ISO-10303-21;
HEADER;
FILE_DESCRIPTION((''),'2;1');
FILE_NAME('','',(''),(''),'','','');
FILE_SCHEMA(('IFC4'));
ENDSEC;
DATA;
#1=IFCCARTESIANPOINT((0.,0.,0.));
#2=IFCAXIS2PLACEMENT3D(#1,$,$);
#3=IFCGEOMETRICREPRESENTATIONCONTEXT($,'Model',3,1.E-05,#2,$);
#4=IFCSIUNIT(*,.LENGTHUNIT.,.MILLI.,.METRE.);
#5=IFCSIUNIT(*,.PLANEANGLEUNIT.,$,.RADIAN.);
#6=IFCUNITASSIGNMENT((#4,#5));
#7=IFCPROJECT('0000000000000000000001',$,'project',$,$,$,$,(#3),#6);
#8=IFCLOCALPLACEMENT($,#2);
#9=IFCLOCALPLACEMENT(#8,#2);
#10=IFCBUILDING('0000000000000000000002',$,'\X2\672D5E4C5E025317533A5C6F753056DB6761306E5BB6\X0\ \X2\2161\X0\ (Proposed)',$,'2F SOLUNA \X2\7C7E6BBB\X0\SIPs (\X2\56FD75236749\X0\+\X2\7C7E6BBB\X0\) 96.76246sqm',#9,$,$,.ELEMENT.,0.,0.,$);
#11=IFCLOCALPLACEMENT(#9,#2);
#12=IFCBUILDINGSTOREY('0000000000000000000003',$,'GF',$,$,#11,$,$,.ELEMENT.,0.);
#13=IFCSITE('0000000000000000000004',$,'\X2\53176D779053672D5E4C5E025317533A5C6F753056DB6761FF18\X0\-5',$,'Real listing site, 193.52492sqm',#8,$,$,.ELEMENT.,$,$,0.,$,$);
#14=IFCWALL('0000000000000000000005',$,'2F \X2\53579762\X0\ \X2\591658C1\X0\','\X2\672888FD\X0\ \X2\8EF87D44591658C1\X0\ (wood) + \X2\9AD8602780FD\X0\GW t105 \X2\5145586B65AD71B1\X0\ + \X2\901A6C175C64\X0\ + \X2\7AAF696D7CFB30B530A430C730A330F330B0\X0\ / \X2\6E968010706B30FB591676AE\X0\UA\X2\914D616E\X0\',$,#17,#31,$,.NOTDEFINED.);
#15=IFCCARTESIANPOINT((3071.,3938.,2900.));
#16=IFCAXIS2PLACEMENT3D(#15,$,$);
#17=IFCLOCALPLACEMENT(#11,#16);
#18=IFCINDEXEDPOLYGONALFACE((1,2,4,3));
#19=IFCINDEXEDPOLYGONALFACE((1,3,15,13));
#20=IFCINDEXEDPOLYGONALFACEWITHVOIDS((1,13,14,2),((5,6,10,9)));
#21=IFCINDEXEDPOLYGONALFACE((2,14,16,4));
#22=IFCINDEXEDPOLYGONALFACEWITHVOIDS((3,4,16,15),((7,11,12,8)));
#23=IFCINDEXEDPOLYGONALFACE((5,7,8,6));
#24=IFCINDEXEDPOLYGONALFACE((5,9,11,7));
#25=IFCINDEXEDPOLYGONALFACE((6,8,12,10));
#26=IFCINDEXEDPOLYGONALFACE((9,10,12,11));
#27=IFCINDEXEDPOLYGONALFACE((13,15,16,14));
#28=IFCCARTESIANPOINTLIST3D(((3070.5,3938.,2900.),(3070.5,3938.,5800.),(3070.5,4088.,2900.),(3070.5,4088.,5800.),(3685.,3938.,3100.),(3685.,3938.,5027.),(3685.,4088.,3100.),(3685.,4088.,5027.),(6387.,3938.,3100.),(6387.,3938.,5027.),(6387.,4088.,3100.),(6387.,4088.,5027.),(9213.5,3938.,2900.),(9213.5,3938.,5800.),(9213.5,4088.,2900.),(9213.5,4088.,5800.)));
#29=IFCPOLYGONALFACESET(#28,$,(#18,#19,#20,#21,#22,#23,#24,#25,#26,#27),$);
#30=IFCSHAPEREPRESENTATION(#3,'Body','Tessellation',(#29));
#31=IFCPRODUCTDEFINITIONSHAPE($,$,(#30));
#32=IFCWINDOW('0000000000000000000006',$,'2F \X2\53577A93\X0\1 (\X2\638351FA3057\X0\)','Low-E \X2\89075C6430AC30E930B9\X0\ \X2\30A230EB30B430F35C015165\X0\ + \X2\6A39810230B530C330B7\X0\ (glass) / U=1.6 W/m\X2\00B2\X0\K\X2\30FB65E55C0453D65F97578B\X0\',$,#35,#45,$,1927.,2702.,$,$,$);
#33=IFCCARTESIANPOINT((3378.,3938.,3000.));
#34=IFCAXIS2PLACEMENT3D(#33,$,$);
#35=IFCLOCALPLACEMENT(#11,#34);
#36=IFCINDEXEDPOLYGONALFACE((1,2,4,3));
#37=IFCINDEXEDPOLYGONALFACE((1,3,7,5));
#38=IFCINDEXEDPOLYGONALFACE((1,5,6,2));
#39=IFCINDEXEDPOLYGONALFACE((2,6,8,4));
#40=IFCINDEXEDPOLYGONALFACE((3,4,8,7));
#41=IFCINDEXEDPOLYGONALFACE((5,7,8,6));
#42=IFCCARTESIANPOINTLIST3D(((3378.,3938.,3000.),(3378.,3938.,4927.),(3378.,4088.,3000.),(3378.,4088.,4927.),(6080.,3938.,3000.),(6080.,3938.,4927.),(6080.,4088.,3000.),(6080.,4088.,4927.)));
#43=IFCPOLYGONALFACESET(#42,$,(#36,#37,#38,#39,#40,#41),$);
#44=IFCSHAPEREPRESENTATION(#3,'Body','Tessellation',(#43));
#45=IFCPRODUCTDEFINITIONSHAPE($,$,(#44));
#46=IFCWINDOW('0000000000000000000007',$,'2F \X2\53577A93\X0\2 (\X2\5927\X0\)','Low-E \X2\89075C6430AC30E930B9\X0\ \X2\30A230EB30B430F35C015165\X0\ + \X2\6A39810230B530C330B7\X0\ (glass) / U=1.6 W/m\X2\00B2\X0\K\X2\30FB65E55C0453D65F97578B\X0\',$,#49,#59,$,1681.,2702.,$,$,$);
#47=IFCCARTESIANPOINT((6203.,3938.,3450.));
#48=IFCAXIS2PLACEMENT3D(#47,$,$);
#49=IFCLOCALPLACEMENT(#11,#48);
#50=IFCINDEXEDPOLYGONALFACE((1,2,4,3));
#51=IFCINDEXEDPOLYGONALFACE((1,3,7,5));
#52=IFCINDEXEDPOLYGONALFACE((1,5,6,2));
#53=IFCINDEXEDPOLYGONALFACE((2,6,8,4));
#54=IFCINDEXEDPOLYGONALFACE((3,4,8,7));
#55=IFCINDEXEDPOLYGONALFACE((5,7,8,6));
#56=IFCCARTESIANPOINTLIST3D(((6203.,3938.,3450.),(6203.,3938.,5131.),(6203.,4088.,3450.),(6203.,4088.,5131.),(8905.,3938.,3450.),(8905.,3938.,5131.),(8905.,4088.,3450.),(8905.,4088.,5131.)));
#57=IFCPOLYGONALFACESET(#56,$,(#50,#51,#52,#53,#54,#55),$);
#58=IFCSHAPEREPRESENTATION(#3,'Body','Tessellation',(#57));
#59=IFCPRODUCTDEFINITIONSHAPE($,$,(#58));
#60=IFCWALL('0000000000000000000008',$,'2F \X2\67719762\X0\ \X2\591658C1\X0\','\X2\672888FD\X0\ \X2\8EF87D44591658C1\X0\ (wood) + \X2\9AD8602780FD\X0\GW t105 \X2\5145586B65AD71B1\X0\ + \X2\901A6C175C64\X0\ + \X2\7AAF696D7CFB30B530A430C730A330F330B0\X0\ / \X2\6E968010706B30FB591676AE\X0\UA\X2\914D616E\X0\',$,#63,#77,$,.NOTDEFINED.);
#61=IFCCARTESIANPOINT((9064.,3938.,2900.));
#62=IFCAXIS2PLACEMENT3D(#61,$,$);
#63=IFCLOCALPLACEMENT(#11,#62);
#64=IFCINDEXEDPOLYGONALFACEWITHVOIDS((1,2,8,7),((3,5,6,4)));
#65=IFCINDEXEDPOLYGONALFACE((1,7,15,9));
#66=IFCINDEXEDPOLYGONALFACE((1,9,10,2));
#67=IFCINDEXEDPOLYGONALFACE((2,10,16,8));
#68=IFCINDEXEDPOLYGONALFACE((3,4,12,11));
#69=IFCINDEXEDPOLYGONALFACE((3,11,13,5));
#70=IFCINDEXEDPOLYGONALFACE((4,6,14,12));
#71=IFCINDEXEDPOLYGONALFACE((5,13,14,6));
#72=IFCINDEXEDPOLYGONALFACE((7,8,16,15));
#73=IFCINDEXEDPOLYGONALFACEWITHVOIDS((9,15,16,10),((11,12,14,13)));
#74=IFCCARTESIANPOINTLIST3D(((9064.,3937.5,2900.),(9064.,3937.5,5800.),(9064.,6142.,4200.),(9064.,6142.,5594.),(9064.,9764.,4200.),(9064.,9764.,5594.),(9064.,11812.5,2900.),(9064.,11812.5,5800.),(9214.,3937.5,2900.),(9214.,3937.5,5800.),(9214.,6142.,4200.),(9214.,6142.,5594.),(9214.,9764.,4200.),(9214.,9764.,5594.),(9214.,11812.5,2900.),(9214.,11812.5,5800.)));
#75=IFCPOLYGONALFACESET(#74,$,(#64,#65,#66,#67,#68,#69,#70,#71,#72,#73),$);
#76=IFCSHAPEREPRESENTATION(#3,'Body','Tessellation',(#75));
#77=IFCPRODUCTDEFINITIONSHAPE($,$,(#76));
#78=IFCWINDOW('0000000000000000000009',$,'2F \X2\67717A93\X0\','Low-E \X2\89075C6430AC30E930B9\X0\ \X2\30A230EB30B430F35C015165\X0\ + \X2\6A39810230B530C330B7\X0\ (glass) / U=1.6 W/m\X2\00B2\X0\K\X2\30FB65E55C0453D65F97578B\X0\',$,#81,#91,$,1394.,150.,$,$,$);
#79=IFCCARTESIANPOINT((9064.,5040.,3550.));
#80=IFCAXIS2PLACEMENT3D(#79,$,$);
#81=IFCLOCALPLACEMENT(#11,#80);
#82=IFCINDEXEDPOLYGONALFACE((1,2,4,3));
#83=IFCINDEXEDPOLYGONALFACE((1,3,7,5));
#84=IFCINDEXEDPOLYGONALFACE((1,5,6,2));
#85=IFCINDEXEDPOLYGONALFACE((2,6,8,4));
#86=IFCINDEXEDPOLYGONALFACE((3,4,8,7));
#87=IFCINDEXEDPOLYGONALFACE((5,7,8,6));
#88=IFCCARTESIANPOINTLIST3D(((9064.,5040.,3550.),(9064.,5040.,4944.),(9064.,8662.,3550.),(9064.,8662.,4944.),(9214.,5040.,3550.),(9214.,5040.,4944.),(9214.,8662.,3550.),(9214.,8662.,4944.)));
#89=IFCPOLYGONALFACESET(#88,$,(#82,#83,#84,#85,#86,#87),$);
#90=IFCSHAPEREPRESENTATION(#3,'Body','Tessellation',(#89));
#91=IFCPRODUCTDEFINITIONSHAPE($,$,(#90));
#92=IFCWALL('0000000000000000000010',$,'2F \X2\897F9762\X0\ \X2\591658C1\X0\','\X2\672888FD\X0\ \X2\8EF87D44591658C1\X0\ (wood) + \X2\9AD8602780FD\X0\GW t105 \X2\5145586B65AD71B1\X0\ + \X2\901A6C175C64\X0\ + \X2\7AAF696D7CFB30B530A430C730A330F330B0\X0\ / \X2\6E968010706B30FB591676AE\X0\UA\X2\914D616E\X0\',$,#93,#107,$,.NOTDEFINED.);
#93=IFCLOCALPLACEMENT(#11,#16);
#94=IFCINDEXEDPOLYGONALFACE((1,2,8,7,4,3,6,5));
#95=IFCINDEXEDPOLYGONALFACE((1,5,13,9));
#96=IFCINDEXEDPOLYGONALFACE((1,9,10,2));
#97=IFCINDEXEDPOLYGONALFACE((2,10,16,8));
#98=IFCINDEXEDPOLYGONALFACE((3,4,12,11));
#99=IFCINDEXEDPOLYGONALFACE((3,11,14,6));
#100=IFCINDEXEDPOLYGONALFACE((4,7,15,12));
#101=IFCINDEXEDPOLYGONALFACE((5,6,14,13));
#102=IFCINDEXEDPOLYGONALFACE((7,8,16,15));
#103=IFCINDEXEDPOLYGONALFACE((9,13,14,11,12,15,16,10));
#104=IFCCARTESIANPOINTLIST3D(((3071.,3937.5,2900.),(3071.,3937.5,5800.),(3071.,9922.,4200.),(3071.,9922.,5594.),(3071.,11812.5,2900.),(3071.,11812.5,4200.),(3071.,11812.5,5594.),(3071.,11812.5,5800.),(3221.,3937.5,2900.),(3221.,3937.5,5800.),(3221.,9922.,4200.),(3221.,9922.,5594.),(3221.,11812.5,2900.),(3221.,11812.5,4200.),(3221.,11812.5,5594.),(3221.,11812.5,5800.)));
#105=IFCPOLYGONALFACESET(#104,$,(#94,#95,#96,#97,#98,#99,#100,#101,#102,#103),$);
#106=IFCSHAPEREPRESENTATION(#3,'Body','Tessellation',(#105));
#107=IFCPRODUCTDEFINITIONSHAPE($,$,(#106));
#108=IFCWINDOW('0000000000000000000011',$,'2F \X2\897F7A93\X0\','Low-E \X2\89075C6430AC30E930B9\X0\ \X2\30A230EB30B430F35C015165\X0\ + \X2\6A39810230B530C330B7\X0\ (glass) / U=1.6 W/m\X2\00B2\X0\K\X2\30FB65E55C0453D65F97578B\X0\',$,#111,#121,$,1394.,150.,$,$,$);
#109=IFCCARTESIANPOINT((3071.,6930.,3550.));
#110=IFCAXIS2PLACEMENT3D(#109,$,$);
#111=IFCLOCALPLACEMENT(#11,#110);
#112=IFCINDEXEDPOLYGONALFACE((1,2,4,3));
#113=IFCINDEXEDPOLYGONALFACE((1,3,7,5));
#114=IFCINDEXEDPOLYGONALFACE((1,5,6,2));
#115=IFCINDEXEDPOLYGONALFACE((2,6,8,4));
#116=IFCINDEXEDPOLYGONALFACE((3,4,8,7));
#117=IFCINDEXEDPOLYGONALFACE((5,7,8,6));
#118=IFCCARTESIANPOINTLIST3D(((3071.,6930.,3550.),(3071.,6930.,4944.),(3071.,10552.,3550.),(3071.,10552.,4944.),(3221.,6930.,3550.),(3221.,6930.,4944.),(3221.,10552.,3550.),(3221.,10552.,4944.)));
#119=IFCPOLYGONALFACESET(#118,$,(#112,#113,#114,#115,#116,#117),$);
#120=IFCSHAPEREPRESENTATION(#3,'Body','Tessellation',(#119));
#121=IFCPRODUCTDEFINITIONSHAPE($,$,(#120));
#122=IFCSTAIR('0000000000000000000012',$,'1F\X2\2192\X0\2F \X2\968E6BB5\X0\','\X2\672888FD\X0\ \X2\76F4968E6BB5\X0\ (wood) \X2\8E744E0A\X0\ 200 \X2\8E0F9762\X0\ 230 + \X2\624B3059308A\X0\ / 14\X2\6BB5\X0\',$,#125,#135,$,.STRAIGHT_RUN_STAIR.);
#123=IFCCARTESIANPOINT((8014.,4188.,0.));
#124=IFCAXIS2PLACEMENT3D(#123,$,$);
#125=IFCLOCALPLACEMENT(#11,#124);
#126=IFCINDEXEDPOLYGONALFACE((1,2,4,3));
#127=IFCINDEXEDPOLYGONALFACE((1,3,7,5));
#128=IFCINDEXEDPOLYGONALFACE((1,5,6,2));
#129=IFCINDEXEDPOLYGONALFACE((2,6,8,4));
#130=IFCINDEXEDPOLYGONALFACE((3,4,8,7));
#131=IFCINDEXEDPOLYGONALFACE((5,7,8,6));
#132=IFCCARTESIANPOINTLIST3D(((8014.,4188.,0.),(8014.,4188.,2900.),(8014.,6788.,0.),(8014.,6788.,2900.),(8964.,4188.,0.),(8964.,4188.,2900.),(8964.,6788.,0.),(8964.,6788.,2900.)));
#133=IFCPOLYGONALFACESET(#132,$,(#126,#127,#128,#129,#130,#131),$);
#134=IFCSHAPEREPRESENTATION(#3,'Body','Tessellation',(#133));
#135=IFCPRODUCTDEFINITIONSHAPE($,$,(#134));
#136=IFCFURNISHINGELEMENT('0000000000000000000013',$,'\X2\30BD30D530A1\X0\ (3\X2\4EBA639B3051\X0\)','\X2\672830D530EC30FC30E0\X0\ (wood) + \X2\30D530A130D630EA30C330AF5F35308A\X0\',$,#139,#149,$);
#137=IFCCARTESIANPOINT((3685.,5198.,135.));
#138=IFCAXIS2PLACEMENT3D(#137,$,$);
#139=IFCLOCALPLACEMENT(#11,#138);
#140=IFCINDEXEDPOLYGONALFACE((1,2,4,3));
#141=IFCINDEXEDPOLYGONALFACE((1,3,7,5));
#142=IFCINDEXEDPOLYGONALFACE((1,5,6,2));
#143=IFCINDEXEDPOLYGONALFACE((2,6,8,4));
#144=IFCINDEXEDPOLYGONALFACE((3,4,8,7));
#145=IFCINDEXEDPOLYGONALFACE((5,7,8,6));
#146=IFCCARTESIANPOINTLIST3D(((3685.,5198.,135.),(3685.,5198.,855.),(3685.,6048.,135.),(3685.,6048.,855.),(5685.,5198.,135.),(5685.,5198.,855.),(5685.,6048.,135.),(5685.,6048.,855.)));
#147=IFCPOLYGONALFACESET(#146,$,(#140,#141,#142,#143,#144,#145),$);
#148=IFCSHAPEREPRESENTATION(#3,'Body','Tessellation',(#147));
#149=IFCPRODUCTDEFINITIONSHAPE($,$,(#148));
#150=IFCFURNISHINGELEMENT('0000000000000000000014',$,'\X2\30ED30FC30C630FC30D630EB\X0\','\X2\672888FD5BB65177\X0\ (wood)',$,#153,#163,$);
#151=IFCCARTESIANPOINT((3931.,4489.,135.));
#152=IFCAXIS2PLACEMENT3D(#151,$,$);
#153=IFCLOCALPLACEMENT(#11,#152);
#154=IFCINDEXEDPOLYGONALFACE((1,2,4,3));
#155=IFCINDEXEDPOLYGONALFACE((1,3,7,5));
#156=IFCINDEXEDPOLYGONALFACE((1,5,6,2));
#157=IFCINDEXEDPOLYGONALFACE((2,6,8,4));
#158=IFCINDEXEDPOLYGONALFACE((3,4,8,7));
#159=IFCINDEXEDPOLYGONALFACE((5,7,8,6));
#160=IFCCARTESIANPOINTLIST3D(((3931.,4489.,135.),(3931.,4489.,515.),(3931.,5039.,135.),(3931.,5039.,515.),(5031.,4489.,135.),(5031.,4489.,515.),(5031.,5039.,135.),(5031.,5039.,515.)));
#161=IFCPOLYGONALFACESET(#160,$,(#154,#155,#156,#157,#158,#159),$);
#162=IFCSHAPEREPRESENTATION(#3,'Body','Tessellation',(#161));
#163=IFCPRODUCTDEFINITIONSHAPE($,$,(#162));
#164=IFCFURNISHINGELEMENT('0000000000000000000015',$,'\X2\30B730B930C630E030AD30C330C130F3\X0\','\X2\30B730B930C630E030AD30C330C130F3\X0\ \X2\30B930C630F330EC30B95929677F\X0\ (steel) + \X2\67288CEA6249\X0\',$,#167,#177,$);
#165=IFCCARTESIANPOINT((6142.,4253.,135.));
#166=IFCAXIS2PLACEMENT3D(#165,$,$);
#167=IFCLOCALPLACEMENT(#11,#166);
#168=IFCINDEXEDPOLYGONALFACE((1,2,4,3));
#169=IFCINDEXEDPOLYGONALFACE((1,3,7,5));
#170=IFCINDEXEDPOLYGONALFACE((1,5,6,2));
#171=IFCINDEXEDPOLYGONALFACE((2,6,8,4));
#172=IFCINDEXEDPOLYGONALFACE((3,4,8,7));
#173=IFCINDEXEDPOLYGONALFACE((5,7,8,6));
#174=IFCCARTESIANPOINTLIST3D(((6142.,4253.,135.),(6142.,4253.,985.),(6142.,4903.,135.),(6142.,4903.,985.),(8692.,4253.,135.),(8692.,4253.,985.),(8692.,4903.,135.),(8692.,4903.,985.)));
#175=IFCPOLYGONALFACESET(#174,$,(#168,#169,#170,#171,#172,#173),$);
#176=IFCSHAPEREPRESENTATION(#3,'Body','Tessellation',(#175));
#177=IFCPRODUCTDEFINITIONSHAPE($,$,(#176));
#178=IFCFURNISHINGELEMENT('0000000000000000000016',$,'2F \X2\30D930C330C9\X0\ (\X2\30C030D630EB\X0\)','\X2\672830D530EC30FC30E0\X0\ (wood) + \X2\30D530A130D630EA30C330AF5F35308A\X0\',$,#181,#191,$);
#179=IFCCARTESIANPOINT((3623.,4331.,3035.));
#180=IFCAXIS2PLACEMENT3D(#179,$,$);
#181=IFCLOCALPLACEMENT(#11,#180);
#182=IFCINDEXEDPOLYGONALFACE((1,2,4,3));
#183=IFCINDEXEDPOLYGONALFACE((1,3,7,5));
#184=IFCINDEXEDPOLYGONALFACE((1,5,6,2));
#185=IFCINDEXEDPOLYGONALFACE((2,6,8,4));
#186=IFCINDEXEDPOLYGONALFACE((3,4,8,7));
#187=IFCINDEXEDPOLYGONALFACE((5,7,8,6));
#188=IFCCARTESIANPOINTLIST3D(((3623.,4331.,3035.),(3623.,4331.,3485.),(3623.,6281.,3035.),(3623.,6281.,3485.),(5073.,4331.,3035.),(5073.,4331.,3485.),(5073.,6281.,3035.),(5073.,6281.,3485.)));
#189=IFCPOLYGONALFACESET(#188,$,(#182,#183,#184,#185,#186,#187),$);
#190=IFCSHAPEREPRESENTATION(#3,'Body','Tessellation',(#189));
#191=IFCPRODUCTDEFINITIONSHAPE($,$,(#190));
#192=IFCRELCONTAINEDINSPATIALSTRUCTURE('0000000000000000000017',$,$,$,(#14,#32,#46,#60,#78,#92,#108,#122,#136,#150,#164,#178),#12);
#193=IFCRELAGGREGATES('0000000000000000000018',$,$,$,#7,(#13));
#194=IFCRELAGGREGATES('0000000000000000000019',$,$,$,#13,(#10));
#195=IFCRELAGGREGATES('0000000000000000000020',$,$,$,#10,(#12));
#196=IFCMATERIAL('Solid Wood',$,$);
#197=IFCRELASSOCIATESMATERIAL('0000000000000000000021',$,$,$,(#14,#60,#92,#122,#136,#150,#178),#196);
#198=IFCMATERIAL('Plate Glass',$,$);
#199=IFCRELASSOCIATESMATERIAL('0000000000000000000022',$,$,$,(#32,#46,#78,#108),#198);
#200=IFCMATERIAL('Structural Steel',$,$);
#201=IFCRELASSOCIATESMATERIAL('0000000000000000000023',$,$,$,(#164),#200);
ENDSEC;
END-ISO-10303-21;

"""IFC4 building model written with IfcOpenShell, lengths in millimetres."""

from ifc_helpers import new_model, si_unit, frame, frame_2d, origin, place, context, project, spatial, rectangle, extrude, material, element, fill, save


model = new_model("IFC4")

# Units and contexts
model_context = context("Model", 3, precision=1e-05, world=origin())
ifc_project = project(units=[si_unit("LENGTHUNIT", "METRE", prefix="MILLI"), si_unit("PLANEANGLEUNIT", "RADIAN")], contexts=[model_context])

# Site, building, storey
site_placement = place(None, origin())
site = spatial("IfcSite", under=ifc_project, at=site_placement, Name="北海道札幌市北区屯田四条８-5", ObjectType="Real listing site, 193.52492sqm", CompositionType="ELEMENT", RefElevation=0.0)
building_placement = place(site_placement, origin())
building = spatial("IfcBuilding", under=site, at=building_placement, Name="札幌市北区屯田四条の家 Ⅱ (Proposed)", ObjectType="2F SOLUNA 籾殻SIPs (国産杉+籾殻) 96.76246sqm", CompositionType="ELEMENT", ElevationOfRefHeight=0.0, ElevationOfTerrain=0.0)
storey_placement = place(building_placement, origin())
storey = spatial("IfcBuildingStorey", under=building, at=storey_placement, Name="GF", CompositionType="ELEMENT", Elevation=0.0)

# Shared definitions
ifc_material_1 = material(Name="Solid Wood")

# Shared definitions
ifc_material_2 = material(Name="Plate Glass")

# Wall, openings, windows
wall_1_placement = place(storey_placement, frame((3071.0, 3938.0, 2900.0)))
wall_1 = element("IfcWall", 1, at=wall_1_placement, inside=storey, material=ifc_material_1, Name="2F 南面 外壁", Description="木製 軸組外壁 (wood) + 高性能GW t105 充填断熱 + 通気層 + 窯業系サイディング / 準耐火・外皮UA配慮", PredefinedType="NOTDEFINED", context=model_context, shape_type="SweptSolid", body=[
    extrude(rectangle(XDim=6143.0, YDim=150.0, at=frame_2d((3071.0, 75.0))), frame((3071.0, 3938.0, 2900.0)), (0.0, 0.0, 1.0), 2900.0),
])
opening_1_placement = place(storey_placement, frame((3378.0, 3938.0, 3000.0)))
opening_1 = element("IfcOpeningElement", 2, at=opening_1_placement, cuts=wall_1, PredefinedType="NOTDEFINED", context=model_context, shape_type="SweptSolid", body=[
    extrude(rectangle(XDim=2702.0, YDim=150.0, at=frame_2d((1351.0, 75.0))), frame((3378.0, 3938.0, 3000.0)), (0.0, 0.0, 1.0), 1927.0),
])
opening_2_placement = place(storey_placement, frame((6203.0, 3938.0, 3450.0)))
opening_2 = element("IfcOpeningElement", 3, at=opening_2_placement, cuts=wall_1, PredefinedType="NOTDEFINED", context=model_context, shape_type="SweptSolid", body=[
    extrude(rectangle(XDim=2702.0, YDim=150.0, at=frame_2d((1351.0, 75.0))), frame((6203.0, 3938.0, 3450.0)), (0.0, 0.0, 1.0), 1681.0),
])
window_1_placement = place(storey_placement, frame((3378.0, 3938.0, 3000.0)))
window_1 = element("IfcWindow", 4, at=window_1_placement, inside=storey, material=ifc_material_2, Name="2F 南窓1 (掃出し)", Description="Low-E 複層ガラス アルゴン封入 + 樹脂サッシ (glass) / U=1.6 W/m²K・日射取得型", OverallHeight=1927.0, OverallWidth=2702.0, context=model_context, shape_type="SweptSolid", body=[
    extrude(rectangle(XDim=2702.0, YDim=150.0, at=frame_2d((1351.0, 75.0))), frame((3378.0, 3938.0, 3000.0)), (0.0, 0.0, 1.0), 1927.0),
])
fill(opening_1, window_1)
window_2_placement = place(storey_placement, frame((6203.0, 3938.0, 3450.0)))
window_2 = element("IfcWindow", 5, at=window_2_placement, inside=storey, material=ifc_material_2, Name="2F 南窓2 (大)", Description="Low-E 複層ガラス アルゴン封入 + 樹脂サッシ (glass) / U=1.6 W/m²K・日射取得型", OverallHeight=1681.0, OverallWidth=2702.0, context=model_context, shape_type="SweptSolid", body=[
    extrude(rectangle(XDim=2702.0, YDim=150.0, at=frame_2d((1351.0, 75.0))), frame((6203.0, 3938.0, 3450.0)), (0.0, 0.0, 1.0), 1681.0),
])
fill(opening_2, window_2)

# Walls, openings, windows
wall_2_placement = place(storey_placement, frame((9064.0, 3938.0, 2900.0)))
wall_2 = element("IfcWall", 6, at=wall_2_placement, inside=storey, material=ifc_material_1, Name="2F 東面 外壁", Description="木製 軸組外壁 (wood) + 高性能GW t105 充填断熱 + 通気層 + 窯業系サイディング / 準耐火・外皮UA配慮", PredefinedType="NOTDEFINED", context=model_context, shape_type="SweptSolid", body=[
    extrude(rectangle(XDim=150.0, YDim=7875.0, at=frame_2d((75.0, 3937.0))), frame((9064.0, 3938.0, 2900.0)), (0.0, 0.0, 1.0), 2900.0),
])
opening_3_placement = place(storey_placement, frame((9064.0, 5040.0, 3550.0)))
opening_3 = element("IfcOpeningElement", 7, at=opening_3_placement, cuts=wall_2, PredefinedType="NOTDEFINED", context=model_context, shape_type="SweptSolid", body=[
    extrude(rectangle(XDim=150.0, YDim=3622.0, at=frame_2d((75.0, 1811.0))), frame((9064.0, 5040.0, 3550.0)), (0.0, 0.0, 1.0), 1394.0),
])
window_3_placement = place(storey_placement, frame((9064.0, 5040.0, 3550.0)))
window_3 = element("IfcWindow", 8, at=window_3_placement, inside=storey, material=ifc_material_2, Name="2F 東窓", Description="Low-E 複層ガラス アルゴン封入 + 樹脂サッシ (glass) / U=1.6 W/m²K・日射取得型", OverallHeight=1394.0, OverallWidth=150.0, context=model_context, shape_type="SweptSolid", body=[
    extrude(rectangle(XDim=150.0, YDim=3622.0, at=frame_2d((75.0, 1811.0))), frame((9064.0, 5040.0, 3550.0)), (0.0, 0.0, 1.0), 1394.0),
])
fill(opening_3, window_3)
wall_3_placement = place(storey_placement, frame((3071.0, 3938.0, 2900.0)))
wall_3 = element("IfcWall", 9, at=wall_3_placement, inside=storey, material=ifc_material_1, Name="2F 西面 外壁", Description="木製 軸組外壁 (wood) + 高性能GW t105 充填断熱 + 通気層 + 窯業系サイディング / 準耐火・外皮UA配慮", PredefinedType="NOTDEFINED", context=model_context, shape_type="SweptSolid", body=[
    extrude(rectangle(XDim=150.0, YDim=7875.0, at=frame_2d((75.0, 3937.0))), frame((3071.0, 3938.0, 2900.0)), (0.0, 0.0, 1.0), 2900.0),
])
opening_4_placement = place(storey_placement, frame((3071.0, 6930.0, 3550.0)))
opening_4 = element("IfcOpeningElement", 10, at=opening_4_placement, cuts=wall_3, PredefinedType="NOTDEFINED", context=model_context, shape_type="SweptSolid", body=[
    extrude(rectangle(XDim=150.0, YDim=3622.0, at=frame_2d((75.0, 1811.0))), frame((3071.0, 6930.0, 3550.0)), (0.0, 0.0, 1.0), 1394.0),
])
window_4_placement = place(storey_placement, frame((3071.0, 6930.0, 3550.0)))
window_4 = element("IfcWindow", 11, at=window_4_placement, inside=storey, material=ifc_material_2, Name="2F 西窓", Description="Low-E 複層ガラス アルゴン封入 + 樹脂サッシ (glass) / U=1.6 W/m²K・日射取得型", OverallHeight=1394.0, OverallWidth=150.0, context=model_context, shape_type="SweptSolid", body=[
    extrude(rectangle(XDim=150.0, YDim=3622.0, at=frame_2d((75.0, 1811.0))), frame((3071.0, 6930.0, 3550.0)), (0.0, 0.0, 1.0), 1394.0),
])
fill(opening_4, window_4)

# Stair
stair_placement = place(storey_placement, frame((8014.0, 4188.0, 0.0)))
element("IfcStair", 12, at=stair_placement, inside=storey, material=ifc_material_1, Name="1F→2F 階段", Description="木製 直階段 (wood) 蹴上 200 踏面 230 + 手すり / 14段", PredefinedType="STRAIGHT_RUN_STAIR", context=model_context, shape_type="SweptSolid", body=[
    extrude(rectangle(XDim=950.0, YDim=2600.0, at=frame_2d((475.0, 1300.0))), frame((8014.0, 4188.0, 0.0)), (0.0, 0.0, 1.0), 2900.0),
])

# Shared definitions
ifc_material_3 = material(Name="Structural Steel")

# Furnishing elements
furnishing_1_placement = place(storey_placement, frame((3685.0, 5198.0, 135.0)))
element("IfcFurnishingElement", 13, at=furnishing_1_placement, inside=storey, material=ifc_material_1, Name="ソファ (3人掛け)", Description="木フレーム (wood) + ファブリック張り", context=model_context, shape_type="SweptSolid", body=[
    extrude(rectangle(XDim=2000.0, YDim=850.0, at=frame_2d((1000.0, 425.0))), frame((3685.0, 5198.0, 135.0)), (0.0, 0.0, 1.0), 720.0),
])
furnishing_2_placement = place(storey_placement, frame((3931.0, 4489.0, 135.0)))
element("IfcFurnishingElement", 14, at=furnishing_2_placement, inside=storey, material=ifc_material_1, Name="ローテーブル", Description="木製家具 (wood)", context=model_context, shape_type="SweptSolid", body=[
    extrude(rectangle(XDim=1100.0, YDim=550.0, at=frame_2d((550.0, 275.0))), frame((3931.0, 4489.0, 135.0)), (0.0, 0.0, 1.0), 380.0),
])
furnishing_3_placement = place(storey_placement, frame((6142.0, 4253.0, 135.0)))
element("IfcFurnishingElement", 15, at=furnishing_3_placement, inside=storey, material=ifc_material_3, Name="システムキッチン", Description="システムキッチン ステンレス天板 (steel) + 木質扉", context=model_context, shape_type="SweptSolid", body=[
    extrude(rectangle(XDim=2550.0, YDim=650.0, at=frame_2d((1275.0, 325.0))), frame((6142.0, 4253.0, 135.0)), (0.0, 0.0, 1.0), 850.0),
])
furnishing_4_placement = place(storey_placement, frame((3623.0, 4331.0, 3035.0)))
element("IfcFurnishingElement", 16, at=furnishing_4_placement, inside=storey, material=ifc_material_1, Name="2F ベッド (ダブル)", Description="木フレーム (wood) + ファブリック張り", context=model_context, shape_type="SweptSolid", body=[
    extrude(rectangle(XDim=1450.0, YDim=1950.0, at=frame_2d((725.0, 975.0))), frame((3623.0, 4331.0, 3035.0)), (0.0, 0.0, 1.0), 450.0),
])

save(model, "model.ifc")
